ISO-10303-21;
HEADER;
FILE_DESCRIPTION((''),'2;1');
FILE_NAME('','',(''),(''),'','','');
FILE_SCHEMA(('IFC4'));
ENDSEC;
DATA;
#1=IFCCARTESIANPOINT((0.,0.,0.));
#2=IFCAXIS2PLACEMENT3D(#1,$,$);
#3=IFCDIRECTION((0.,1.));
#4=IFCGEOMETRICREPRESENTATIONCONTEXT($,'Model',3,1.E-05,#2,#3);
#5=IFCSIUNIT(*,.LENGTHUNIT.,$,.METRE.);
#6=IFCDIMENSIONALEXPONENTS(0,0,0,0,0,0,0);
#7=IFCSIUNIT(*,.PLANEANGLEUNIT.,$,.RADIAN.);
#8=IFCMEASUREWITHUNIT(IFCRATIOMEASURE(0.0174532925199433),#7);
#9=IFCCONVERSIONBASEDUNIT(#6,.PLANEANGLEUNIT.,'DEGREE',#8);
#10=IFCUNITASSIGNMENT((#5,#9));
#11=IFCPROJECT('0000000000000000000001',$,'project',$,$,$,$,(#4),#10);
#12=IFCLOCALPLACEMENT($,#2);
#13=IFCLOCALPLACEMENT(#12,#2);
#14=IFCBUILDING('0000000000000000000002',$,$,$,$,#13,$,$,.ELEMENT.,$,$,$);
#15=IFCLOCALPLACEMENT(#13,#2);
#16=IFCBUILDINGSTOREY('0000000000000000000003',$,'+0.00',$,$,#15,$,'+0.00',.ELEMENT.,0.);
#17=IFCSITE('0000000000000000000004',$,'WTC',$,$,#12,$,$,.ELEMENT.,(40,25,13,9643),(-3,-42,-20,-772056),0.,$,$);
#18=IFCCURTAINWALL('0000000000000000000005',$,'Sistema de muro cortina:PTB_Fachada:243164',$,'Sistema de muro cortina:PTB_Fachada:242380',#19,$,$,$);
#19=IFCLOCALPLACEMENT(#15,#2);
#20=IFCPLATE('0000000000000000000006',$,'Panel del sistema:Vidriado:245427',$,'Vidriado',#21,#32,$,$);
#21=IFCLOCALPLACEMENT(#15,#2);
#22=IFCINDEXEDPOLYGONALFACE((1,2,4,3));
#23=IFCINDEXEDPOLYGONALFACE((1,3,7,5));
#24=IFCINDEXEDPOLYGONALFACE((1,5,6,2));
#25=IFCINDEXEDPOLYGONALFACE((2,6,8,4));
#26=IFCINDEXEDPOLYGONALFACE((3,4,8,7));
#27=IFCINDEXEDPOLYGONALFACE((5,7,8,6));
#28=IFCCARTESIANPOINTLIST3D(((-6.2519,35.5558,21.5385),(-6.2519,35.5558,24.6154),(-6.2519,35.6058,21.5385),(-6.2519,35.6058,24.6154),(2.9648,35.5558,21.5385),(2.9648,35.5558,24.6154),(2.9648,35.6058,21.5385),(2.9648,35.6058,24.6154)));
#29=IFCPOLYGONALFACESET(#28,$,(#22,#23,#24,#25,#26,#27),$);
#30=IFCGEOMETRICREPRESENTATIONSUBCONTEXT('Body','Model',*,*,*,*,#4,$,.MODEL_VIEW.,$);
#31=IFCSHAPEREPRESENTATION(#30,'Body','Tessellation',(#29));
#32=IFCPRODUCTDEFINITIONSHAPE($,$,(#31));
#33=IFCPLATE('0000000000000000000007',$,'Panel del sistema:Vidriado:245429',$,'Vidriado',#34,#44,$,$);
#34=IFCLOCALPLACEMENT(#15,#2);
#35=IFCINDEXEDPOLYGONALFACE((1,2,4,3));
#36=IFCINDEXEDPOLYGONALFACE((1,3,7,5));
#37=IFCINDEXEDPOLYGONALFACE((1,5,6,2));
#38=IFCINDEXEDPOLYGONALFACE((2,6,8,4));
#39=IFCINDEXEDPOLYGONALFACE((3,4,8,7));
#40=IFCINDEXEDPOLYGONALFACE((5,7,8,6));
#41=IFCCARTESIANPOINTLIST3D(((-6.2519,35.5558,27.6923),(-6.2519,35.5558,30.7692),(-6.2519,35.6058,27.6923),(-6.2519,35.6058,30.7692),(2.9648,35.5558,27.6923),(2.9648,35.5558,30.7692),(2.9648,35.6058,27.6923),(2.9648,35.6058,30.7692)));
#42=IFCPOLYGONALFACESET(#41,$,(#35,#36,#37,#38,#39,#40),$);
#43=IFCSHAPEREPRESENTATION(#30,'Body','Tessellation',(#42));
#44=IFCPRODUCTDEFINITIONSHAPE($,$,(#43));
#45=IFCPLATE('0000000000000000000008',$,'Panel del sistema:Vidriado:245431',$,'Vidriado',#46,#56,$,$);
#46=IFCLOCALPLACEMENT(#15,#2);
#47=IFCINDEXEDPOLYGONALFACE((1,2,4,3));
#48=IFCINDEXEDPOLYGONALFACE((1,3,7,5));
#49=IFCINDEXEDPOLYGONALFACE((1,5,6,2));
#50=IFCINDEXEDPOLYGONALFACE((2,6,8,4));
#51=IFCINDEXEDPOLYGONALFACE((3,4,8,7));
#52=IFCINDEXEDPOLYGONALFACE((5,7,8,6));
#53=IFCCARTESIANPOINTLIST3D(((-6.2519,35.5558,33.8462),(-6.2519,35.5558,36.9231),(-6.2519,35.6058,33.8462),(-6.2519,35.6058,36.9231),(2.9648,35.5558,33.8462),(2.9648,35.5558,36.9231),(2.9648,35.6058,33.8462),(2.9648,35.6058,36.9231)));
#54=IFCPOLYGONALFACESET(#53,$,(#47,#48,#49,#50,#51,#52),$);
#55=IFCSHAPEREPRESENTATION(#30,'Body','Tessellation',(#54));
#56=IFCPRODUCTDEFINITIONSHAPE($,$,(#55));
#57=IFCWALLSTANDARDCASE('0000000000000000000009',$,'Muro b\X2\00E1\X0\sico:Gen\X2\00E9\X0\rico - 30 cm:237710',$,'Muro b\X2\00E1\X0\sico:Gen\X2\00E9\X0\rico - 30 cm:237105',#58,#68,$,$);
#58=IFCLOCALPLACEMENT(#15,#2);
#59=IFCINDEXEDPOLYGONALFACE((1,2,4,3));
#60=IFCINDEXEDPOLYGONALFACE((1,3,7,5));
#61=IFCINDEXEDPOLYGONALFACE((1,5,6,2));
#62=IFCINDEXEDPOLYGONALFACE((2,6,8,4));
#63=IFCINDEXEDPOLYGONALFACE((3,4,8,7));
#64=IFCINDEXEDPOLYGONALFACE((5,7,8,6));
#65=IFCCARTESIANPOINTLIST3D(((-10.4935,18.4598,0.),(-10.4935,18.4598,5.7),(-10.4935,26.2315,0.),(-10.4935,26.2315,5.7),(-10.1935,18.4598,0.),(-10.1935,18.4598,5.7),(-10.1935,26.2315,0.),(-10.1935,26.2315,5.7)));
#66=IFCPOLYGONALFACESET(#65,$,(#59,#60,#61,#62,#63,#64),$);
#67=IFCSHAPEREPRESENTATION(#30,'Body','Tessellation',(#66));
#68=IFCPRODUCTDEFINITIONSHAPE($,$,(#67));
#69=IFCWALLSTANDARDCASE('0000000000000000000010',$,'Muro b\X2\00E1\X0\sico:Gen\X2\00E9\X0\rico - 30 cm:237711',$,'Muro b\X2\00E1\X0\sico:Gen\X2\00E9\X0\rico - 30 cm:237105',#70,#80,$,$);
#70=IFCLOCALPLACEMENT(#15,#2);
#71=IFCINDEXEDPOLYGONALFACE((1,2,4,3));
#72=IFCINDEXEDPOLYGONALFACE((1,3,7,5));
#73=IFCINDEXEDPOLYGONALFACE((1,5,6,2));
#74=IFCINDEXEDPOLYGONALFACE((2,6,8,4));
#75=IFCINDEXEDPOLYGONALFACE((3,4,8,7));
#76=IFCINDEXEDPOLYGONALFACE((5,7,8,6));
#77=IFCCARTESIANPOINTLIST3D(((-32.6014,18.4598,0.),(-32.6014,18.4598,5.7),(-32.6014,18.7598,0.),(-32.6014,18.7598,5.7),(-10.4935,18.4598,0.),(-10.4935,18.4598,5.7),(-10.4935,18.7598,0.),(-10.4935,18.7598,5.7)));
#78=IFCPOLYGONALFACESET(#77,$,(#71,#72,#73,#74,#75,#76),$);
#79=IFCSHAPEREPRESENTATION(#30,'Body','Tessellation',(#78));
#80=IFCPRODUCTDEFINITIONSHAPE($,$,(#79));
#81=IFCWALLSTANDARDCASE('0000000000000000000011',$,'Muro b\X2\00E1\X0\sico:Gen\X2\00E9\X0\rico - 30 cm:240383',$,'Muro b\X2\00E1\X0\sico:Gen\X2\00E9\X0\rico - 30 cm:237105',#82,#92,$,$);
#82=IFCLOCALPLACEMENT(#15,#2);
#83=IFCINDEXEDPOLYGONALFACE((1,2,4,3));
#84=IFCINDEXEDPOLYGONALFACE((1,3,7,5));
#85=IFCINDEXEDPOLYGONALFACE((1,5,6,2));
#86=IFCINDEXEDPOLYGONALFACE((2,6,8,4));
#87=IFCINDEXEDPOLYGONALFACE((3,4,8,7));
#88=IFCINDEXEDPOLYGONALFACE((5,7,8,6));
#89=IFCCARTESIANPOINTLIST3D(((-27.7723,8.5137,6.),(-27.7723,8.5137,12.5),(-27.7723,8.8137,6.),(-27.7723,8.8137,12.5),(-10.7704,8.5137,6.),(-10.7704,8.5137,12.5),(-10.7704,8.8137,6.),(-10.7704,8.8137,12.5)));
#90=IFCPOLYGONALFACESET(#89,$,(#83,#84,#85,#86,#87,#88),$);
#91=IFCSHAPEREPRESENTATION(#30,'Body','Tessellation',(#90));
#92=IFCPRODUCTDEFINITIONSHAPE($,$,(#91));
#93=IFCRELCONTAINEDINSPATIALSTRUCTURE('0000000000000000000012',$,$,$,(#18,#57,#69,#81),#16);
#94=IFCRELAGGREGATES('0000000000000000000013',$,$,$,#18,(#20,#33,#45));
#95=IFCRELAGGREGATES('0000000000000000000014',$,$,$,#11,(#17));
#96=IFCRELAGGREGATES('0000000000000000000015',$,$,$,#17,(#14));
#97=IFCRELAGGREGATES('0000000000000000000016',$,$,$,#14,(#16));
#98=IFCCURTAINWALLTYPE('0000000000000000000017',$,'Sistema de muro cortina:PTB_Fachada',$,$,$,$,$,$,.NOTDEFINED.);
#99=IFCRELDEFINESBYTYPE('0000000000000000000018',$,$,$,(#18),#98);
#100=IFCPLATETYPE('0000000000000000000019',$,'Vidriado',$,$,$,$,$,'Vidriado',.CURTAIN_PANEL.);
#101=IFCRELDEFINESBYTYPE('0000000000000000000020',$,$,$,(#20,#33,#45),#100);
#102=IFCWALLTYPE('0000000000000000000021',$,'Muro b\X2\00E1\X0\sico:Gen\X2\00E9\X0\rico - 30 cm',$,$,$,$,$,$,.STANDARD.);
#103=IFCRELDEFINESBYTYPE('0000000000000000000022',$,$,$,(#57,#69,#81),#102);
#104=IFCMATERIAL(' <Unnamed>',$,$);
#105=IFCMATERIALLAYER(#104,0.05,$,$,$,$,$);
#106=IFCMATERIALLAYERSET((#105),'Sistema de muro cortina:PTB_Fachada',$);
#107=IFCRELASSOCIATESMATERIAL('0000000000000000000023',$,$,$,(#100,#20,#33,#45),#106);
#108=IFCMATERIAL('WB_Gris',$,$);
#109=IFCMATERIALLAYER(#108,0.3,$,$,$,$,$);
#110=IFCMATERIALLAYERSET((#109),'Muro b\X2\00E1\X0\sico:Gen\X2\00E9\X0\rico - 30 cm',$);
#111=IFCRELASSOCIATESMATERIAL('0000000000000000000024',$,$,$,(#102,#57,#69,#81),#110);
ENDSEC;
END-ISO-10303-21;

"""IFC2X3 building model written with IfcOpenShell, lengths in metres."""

from ifc_helpers import new_model, entity, si_unit, converted_unit, direction, frame, frame_2d, origin, origin_2d_with_axis, place, context, subcontext, project, spatial, polyline, rectangle, extrude, clip, bounded_halfspace, source, transform, mapped, material, layer, layer_set, layer_usage, type_object, type_shapes, element, aggregate, save


model = new_model("IFC2X3")

# Units and contexts
model_context = context("Model", 3, precision=1e-05, world=origin(), true_north=direction((0.0, 1.0)))
body_context = subcontext(model_context, "Body", "Model", "MODEL_VIEW")
ifc_project = project(units=[si_unit("LENGTHUNIT", "METRE"), converted_unit("PLANEANGLEUNIT", "DEGREE", entity("IfcRatioMeasure", 0.0174532925199433), si_unit("PLANEANGLEUNIT", "RADIAN"), dimensions=[0, 0, 0, 0, 0, 0, 0])], contexts=[model_context])

# Site, building, storey
site_placement = place(None, origin())
site = spatial("IfcSite", under=ifc_project, at=site_placement, Name="WTC", CompositionType="ELEMENT", RefLatitude=(40, 25, 13, 9643), RefLongitude=(-3, -42, -20, -772056), RefElevation=0.0)
building_placement = place(site_placement, origin())
building = spatial("IfcBuilding", under=site, at=building_placement, CompositionType="ELEMENT")
storey_placement = place(building_placement, origin())
storey = spatial("IfcBuildingStorey", under=building, at=storey_placement, Name="+0.00", LongName="+0.00", CompositionType="ELEMENT", Elevation=0.0)

# Curtain wall, plates
curtain_wall_type = type_object("IfcCurtainWallType", Name="Sistema de muro cortina:PTB_Fachada", PredefinedType="NOTDEFINED")
ifc_material_1 = material(Name=" <Unnamed>")
ifc_layer_1 = layer(ifc_material_1, 0.05)
ifc_layer_set_1 = layer_set([ifc_layer_1], Name="Sistema de muro cortina:PTB_Fachada")
curtain_wall_1_placement = place(storey_placement, origin())
curtain_wall_1 = element("IfcCurtainWall", 1, at=curtain_wall_1_placement, inside=storey, type_object=curtain_wall_type, Name="Sistema de muro cortina:PTB_Fachada:243164", ObjectType="Sistema de muro cortina:PTB_Fachada:242380")
plate_type_1 = type_object("IfcPlateType", Name="Vidriado", ElementType="Vidriado", PredefinedType="CURTAIN_PANEL", material=ifc_layer_set_1)
shared_shape_1 = source(origin(), body_context, "Body", "SweptSolid", [
    extrude(rectangle(XDim=0.05, YDim=9.2166, at=origin_2d_with_axis()), frame((0.0, 0.0, 0.0), z_axis=(0.0, 0.0, 1.0), x_axis=(0.0, 1.0, 0.0)), (0.0, 0.0, 1.0), 3.0769),
])
type_shapes(plate_type_1, [shared_shape_1])
ifc_layer_usage_1 = layer_usage(ifc_layer_set_1, "AXIS3", "POSITIVE", 0.0)
plate_1_placement = place(curtain_wall_1_placement, frame((-1.6436, 35.5808, 21.5385), z_axis=(0.0, 0.0, 1.0), x_axis=(-1.0, 0.0, 0.0)))
plate_1 = element("IfcPlate", 2, at=plate_1_placement, type_object=plate_type_1, material=ifc_layer_usage_1, Name="Panel del sistema:Vidriado:245427", ObjectType="Vidriado", context=body_context, shape_type="MappedRepresentation", body=[
    mapped(shared_shape_1, transform((0.0, 0.0, 0.0), scale=1.0)),
])
ifc_layer_usage_2 = layer_usage(ifc_layer_set_1, "AXIS3", "POSITIVE", 0.0)
plate_2_placement = place(curtain_wall_1_placement, frame((-1.6436, 35.5808, 27.6923), z_axis=(0.0, 0.0, 1.0), x_axis=(-1.0, 0.0, 0.0)))
plate_2 = element("IfcPlate", 3, at=plate_2_placement, type_object=plate_type_1, material=ifc_layer_usage_2, Name="Panel del sistema:Vidriado:245429", ObjectType="Vidriado", context=body_context, shape_type="MappedRepresentation", body=[
    mapped(shared_shape_1, transform((0.0, 0.0, 0.0), scale=1.0)),
])
ifc_layer_usage_3 = layer_usage(ifc_layer_set_1, "AXIS3", "POSITIVE", 0.0)
plate_3_placement = place(curtain_wall_1_placement, frame((-1.6436, 35.5808, 33.8462), z_axis=(0.0, 0.0, 1.0), x_axis=(-1.0, 0.0, 0.0)))
plate_3 = element("IfcPlate", 4, at=plate_3_placement, type_object=plate_type_1, material=ifc_layer_usage_3, Name="Panel del sistema:Vidriado:245431", ObjectType="Vidriado", context=body_context, shape_type="MappedRepresentation", body=[
    mapped(shared_shape_1, transform((0.0, 0.0, 0.0), scale=1.0)),
])
aggregate(curtain_wall_1, [plate_1, plate_2, plate_3])

# Walls
ifc_material_2 = material(Name="WB_Gris")
ifc_layer_2 = layer(ifc_material_2, 0.3)
ifc_layer_set_2 = layer_set([ifc_layer_2], Name="Muro básico:Genérico - 30 cm")
wall_type = type_object("IfcWallType", Name="Muro básico:Genérico - 30 cm", PredefinedType="STANDARD", material=ifc_layer_set_2)
ifc_layer_usage_4 = layer_usage(ifc_layer_set_2, "AXIS2", "POSITIVE", -0.15)
wall_1_placement = place(storey_placement, frame((-10.3435, 26.2315, 0.0), z_axis=(0.0, 0.0, 1.0), x_axis=(0.0, -1.0, 0.0)))
element("IfcWallStandardCase", 5, at=wall_1_placement, inside=storey, type_object=wall_type, material=ifc_layer_usage_4, Name="Muro básico:Genérico - 30 cm:237710", ObjectType="Muro básico:Genérico - 30 cm:237105", context=body_context, shape_type="Clipping", body=[
    clip(extrude(rectangle(XDim=7.7717, YDim=0.3, at=frame_2d((3.8858, 0.0), x_axis=(-1.0, 0.0))), origin(), (0.0, 0.0, 1.0), 5.7), bounded_halfspace(frame((7.4717, -0.15, 5.7), z_axis=(0.0, 0.0, 1.0), x_axis=(-1.0, 0.0, 0.0)), False, frame((7.4717, -0.15, 5.7), z_axis=(0.0, 0.0, 1.0), x_axis=(-1.0, 0.0, 0.0)), polyline([(0.0, 0.0), (-0.3, 0.0), (-0.3, -0.3), (7.4717, -0.3), (7.4717, 0.0), (0.0, 0.0)]))),
])
ifc_layer_usage_5 = layer_usage(ifc_layer_set_2, "AXIS2", "POSITIVE", -0.15)
wall_2_placement = place(storey_placement, frame((-10.4935, 18.6098, 0.0), z_axis=(0.0, 0.0, 1.0), x_axis=(-1.0, 0.0, 0.0)))
element("IfcWallStandardCase", 6, at=wall_2_placement, inside=storey, type_object=wall_type, material=ifc_layer_usage_5, Name="Muro básico:Genérico - 30 cm:237711", ObjectType="Muro básico:Genérico - 30 cm:237105", context=body_context, shape_type="Clipping", body=[
    clip(extrude(rectangle(XDim=22.1079, YDim=0.3, at=frame_2d((11.0539, 0.0), x_axis=(-1.0, 0.0))), origin(), (0.0, 0.0, 1.0), 5.7), bounded_halfspace(frame((0.0, -0.15, 5.7), z_axis=(0.0, 0.0, 1.0), x_axis=(0.0, -1.0, 0.0)), False, frame((0.0, -0.15, 5.7), z_axis=(0.0, 0.0, 1.0), x_axis=(0.0, -1.0, 0.0)), polyline([(0.0, 0.0), (0.0, 22.1079), (-0.3, 22.1079), (-0.3, 0.0), (0.0, 0.0)]))),
])
ifc_layer_usage_6 = layer_usage(ifc_layer_set_2, "AXIS2", "POSITIVE", -0.15)
wall_3_placement = place(storey_placement, frame((-10.7704, 8.6637, 6.0), z_axis=(0.0, 0.0, 1.0), x_axis=(-1.0, 0.0, 0.0)))
element("IfcWallStandardCase", 7, at=wall_3_placement, inside=storey, type_object=wall_type, material=ifc_layer_usage_6, Name="Muro básico:Genérico - 30 cm:240383", ObjectType="Muro básico:Genérico - 30 cm:237105", context=body_context, shape_type="SweptSolid", body=[
    extrude(rectangle(XDim=17.0019, YDim=0.3, at=frame_2d((8.501, 0.0), x_axis=(-1.0, 0.0))), origin(), (0.0, 0.0, 1.0), 6.5),
])

save(model, "model.ifc")
